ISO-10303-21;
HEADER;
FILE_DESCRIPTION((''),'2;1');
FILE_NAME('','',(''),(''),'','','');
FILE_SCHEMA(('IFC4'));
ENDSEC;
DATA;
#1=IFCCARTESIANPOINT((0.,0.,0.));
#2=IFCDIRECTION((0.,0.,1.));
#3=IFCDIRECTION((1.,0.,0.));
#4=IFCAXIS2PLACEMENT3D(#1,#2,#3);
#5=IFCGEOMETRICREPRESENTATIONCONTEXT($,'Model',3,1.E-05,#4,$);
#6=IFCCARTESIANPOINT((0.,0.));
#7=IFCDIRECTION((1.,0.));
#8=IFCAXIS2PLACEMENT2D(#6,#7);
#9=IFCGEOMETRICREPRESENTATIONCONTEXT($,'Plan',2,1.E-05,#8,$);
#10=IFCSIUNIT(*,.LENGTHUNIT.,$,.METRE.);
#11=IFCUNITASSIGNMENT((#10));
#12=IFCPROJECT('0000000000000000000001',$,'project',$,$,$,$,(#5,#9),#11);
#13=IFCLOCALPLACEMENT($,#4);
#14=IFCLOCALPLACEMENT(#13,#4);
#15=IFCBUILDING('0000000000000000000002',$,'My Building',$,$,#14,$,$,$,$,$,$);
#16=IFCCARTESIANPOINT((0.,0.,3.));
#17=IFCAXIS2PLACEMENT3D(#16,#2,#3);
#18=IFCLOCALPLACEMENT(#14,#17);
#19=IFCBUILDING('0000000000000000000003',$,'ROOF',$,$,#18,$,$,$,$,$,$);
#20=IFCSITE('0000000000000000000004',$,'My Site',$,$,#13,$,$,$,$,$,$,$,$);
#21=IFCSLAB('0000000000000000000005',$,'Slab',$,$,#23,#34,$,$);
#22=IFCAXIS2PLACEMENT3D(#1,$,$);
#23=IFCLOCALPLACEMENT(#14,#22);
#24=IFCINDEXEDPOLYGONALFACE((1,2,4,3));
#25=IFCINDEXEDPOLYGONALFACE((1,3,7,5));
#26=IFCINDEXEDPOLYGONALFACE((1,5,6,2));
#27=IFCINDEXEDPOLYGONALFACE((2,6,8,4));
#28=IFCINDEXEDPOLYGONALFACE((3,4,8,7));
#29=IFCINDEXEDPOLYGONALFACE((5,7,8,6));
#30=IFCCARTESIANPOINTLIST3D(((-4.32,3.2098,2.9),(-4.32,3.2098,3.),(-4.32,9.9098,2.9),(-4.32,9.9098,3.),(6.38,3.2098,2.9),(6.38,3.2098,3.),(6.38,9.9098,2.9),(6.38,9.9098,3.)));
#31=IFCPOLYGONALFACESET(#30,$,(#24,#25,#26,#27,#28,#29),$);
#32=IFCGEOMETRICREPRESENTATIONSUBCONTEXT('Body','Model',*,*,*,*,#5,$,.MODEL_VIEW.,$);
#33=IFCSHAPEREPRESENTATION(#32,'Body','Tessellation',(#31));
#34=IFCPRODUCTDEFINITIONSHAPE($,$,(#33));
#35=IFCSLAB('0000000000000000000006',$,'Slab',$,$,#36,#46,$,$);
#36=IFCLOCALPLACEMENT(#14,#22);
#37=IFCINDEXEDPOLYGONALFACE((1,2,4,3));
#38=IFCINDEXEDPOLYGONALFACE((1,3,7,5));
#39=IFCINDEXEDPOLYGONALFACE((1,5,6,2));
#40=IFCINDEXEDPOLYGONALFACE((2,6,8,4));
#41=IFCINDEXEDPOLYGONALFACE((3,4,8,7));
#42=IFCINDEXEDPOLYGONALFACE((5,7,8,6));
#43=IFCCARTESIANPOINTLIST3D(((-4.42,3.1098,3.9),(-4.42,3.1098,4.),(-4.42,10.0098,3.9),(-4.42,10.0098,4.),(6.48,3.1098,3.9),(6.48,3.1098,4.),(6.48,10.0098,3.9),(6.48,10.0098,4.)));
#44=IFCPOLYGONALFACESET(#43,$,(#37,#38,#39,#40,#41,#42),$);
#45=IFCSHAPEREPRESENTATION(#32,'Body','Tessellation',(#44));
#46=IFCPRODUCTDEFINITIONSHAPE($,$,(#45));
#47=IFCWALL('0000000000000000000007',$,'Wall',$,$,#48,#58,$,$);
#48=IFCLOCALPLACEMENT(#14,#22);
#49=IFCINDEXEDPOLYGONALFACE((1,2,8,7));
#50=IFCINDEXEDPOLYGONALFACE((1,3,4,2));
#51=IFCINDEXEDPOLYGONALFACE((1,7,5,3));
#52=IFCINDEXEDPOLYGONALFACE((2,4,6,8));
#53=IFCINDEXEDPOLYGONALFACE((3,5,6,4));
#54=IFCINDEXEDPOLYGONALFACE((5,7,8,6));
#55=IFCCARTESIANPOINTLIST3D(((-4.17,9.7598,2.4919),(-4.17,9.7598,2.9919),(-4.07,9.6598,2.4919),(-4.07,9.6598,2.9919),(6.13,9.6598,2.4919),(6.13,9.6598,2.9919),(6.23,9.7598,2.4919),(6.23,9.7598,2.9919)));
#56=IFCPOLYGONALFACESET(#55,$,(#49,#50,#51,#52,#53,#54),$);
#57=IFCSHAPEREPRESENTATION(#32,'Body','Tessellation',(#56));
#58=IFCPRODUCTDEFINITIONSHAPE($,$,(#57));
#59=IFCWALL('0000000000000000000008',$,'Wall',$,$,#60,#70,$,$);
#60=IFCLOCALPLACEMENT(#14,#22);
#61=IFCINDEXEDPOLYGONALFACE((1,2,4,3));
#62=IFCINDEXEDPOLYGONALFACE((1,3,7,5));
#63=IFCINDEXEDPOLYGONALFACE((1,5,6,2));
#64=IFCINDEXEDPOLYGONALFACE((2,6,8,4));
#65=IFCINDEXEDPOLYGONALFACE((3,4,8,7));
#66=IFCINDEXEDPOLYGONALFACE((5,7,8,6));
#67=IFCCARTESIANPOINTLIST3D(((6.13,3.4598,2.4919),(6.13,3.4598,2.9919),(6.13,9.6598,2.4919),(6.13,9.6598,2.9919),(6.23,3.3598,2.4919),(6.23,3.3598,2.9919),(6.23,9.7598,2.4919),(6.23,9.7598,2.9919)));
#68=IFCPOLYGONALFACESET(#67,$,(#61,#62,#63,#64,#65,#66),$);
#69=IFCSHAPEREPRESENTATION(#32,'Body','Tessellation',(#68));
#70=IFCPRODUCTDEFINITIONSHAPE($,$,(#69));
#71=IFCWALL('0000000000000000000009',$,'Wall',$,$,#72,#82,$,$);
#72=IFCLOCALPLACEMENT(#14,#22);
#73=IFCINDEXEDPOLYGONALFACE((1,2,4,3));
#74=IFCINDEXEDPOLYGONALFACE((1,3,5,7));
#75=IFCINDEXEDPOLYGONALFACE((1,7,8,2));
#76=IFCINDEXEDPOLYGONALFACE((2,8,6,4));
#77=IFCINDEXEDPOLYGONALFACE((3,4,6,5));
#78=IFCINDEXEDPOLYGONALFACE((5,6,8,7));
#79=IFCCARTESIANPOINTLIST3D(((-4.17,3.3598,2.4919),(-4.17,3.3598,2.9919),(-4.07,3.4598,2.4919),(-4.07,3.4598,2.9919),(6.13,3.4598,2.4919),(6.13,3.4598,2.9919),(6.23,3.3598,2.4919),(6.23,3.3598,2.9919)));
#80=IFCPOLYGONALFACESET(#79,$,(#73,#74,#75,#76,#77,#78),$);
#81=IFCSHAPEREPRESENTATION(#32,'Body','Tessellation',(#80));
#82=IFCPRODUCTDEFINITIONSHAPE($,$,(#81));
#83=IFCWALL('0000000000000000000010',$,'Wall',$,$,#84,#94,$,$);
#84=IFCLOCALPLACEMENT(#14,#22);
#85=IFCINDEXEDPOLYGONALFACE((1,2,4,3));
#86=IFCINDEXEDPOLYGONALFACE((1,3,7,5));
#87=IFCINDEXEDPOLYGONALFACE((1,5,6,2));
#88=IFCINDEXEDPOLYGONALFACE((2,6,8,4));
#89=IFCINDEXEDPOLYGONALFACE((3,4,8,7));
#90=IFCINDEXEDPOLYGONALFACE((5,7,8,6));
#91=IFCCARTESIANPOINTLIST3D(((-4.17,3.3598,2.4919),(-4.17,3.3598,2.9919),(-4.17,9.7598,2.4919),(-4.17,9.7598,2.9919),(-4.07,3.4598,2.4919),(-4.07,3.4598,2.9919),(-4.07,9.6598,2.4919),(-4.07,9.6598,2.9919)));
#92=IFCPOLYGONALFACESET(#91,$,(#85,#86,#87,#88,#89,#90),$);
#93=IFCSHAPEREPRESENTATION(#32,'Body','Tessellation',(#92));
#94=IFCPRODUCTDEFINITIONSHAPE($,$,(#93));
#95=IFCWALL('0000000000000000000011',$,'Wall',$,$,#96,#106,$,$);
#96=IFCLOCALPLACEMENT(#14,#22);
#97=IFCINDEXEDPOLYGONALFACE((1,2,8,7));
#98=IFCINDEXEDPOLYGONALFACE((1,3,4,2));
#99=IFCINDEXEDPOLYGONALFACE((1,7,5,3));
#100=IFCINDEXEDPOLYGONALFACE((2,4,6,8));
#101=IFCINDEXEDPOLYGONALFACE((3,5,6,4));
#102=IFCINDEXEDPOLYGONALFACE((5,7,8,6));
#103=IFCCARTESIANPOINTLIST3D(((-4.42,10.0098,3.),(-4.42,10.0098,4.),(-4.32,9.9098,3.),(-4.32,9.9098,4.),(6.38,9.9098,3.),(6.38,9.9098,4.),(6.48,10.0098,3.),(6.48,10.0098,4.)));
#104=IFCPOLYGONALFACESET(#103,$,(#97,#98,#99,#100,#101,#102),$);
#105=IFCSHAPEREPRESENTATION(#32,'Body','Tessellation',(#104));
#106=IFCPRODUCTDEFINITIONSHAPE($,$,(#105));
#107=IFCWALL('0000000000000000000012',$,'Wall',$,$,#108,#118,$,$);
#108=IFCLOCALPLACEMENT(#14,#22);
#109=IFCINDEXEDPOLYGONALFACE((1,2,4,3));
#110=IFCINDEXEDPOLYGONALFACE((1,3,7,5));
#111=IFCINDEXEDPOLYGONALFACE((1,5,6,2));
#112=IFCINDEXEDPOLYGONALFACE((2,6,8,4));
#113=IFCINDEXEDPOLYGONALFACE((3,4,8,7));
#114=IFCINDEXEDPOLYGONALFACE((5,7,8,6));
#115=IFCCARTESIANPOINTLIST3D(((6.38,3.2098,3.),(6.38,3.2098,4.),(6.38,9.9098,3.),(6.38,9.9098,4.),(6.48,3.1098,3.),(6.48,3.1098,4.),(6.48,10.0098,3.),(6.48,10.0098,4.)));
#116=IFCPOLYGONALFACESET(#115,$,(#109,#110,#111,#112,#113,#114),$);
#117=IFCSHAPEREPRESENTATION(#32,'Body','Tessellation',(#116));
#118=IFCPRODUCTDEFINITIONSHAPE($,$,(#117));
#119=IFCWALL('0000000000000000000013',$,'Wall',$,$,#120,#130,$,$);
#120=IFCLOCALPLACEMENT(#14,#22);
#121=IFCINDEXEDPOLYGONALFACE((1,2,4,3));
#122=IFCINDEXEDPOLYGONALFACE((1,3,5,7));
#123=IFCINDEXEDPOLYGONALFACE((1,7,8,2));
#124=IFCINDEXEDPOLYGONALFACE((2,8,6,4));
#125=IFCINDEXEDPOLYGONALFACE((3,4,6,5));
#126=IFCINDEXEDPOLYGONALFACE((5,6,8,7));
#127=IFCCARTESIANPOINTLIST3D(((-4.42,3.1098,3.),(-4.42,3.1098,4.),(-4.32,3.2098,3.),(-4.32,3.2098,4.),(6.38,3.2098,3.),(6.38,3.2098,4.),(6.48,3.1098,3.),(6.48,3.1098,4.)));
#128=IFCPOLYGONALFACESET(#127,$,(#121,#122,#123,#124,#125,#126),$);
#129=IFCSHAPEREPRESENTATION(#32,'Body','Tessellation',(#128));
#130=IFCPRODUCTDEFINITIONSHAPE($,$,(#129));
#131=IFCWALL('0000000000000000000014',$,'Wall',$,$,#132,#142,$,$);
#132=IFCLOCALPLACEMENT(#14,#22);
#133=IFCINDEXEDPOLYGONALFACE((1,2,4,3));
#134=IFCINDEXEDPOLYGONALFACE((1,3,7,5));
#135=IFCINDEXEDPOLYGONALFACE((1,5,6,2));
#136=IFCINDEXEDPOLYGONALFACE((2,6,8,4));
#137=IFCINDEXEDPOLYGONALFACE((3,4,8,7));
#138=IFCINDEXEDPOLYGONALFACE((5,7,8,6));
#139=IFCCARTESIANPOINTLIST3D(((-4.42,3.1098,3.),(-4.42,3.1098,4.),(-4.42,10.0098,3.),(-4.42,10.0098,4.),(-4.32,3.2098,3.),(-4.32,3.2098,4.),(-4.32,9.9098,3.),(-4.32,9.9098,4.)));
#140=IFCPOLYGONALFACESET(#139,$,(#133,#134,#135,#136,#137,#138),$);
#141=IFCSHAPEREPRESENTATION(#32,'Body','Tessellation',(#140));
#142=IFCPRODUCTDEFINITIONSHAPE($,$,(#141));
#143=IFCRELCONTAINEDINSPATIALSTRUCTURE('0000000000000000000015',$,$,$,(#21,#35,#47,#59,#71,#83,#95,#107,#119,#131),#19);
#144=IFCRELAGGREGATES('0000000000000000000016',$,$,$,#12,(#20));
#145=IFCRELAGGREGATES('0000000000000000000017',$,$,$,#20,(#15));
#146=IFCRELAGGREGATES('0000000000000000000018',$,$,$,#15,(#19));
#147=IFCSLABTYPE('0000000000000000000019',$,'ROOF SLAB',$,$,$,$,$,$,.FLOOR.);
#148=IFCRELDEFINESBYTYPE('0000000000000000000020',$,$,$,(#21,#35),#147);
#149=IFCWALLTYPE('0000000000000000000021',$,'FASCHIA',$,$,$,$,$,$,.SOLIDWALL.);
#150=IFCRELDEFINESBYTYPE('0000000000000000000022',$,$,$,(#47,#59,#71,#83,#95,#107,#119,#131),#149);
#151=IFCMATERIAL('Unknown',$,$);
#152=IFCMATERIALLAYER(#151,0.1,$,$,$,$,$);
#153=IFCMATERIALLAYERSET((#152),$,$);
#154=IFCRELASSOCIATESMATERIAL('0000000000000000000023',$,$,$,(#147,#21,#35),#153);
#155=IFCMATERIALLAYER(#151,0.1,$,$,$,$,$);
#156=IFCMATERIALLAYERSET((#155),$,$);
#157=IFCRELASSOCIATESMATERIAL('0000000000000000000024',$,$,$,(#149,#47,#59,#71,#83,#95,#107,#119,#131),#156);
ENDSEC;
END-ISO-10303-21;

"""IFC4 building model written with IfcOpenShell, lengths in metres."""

from ifc_helpers import new_model, si_unit, frame, origin_with_axes, origin_2d_with_axis, place, context, subcontext, project, spatial, line, indexed_curve, outline, extrude, material, layer, layer_set, layer_usage, type_object, element, save


model = new_model("IFC4")

# Units and contexts
model_context = context("Model", 3, precision=1e-05, world=origin_with_axes())
plan_context = context("Plan", 2, precision=1e-05, world=origin_2d_with_axis())
body_context = subcontext(model_context, "Body", "Model", "MODEL_VIEW")
ifc_project = project(units=[si_unit("LENGTHUNIT", "METRE")], contexts=[model_context, plan_context])

# Site, buildings
site_placement = place(None, origin_with_axes())
site = spatial("IfcSite", under=ifc_project, at=site_placement, Name="My Site")
building_1_placement = place(site_placement, origin_with_axes())
building_1 = spatial("IfcBuilding", under=site, at=building_1_placement, Name="My Building")
building_2_placement = place(building_1_placement, frame((0.0, 0.0, 3.0), z_axis=(0.0, 0.0, 1.0), x_axis=(1.0, 0.0, 0.0)))
building_2 = spatial("IfcBuilding", under=building_1, at=building_2_placement, Name="ROOF")

# Slabs
ifc_material = material(Name="Unknown")
ifc_layer_1 = layer(ifc_material, 0.1)
ifc_layer_set_1 = layer_set([ifc_layer_1])
ifc_layer_usage_1 = layer_usage(ifc_layer_set_1, "AXIS3", "POSITIVE", -0.1)
slab_type = type_object("IfcSlabType", Name="ROOF SLAB", PredefinedType="FLOOR", material=ifc_layer_set_1)
slab_1_placement = place(building_2_placement, frame((-4.32, 9.9098, 0.0), z_axis=(0.0, 0.0, 1.0), x_axis=(1.0, 0.0, 0.0)))
element("IfcSlab", 1, at=slab_1_placement, inside=building_2, type_object=slab_type, material=ifc_layer_usage_1, Name="Slab", context=body_context, shape_type="SweptSolid", body=[
    extrude(outline(indexed_curve([(0.0, 0.0), (10.7, 0.0), (10.7, -6.7), (0.0, -6.7), (0.0, 0.0)])), frame((0.0, 0.0, -0.1), z_axis=(0.0, 0.0, 1.0), x_axis=(1.0, 0.0, 0.0)), (0.0, 0.0, 1.0), 0.1),
])
ifc_layer_usage_2 = layer_usage(ifc_layer_set_1, "AXIS3", "POSITIVE", -0.1)
slab_2_placement = place(building_2_placement, frame((-4.42, 10.0098, 1.0), z_axis=(0.0, 0.0, 1.0), x_axis=(1.0, 0.0, 0.0)))
element("IfcSlab", 2, at=slab_2_placement, inside=building_2, type_object=slab_type, material=ifc_layer_usage_2, Name="Slab", context=body_context, shape_type="SweptSolid", body=[
    extrude(outline(indexed_curve([(0.0, 0.0), (10.9, 0.0), (10.9, -6.9), (0.0, -6.9), (0.0, 0.0)])), frame((0.0, 0.0, -0.1), z_axis=(0.0, 0.0, 1.0), x_axis=(1.0, 0.0, 0.0)), (0.0, 0.0, 1.0), 0.1),
])

# Walls
ifc_layer_2 = layer(ifc_material, 0.1)
ifc_layer_set_2 = layer_set([ifc_layer_2])
ifc_layer_usage_3 = layer_usage(ifc_layer_set_2, "AXIS2", "POSITIVE", 0.0)
wall_type = type_object("IfcWallType", Name="FASCHIA", PredefinedType="SOLIDWALL", material=ifc_layer_set_2)
wall_1_placement = place(building_2_placement, frame((-4.07, 9.6598, -0.5081), z_axis=(0.0, 0.0, 1.0), x_axis=(1.0, 0.0, 0.0)))
element("IfcWall", 3, at=wall_1_placement, inside=building_2, type_object=wall_type, material=ifc_layer_usage_3, Name="Wall", context=body_context, shape_type="SweptSolid", body=[
    extrude(outline(indexed_curve([(0.0, 0.0), (-0.1, 0.1), (10.3, 0.1), (10.2, 0.0)], segments=[line(1, 2, 3, 4, 1)])), origin_with_axes(), (0.0, 0.0, 1.0), 0.5),
])
ifc_layer_usage_4 = layer_usage(ifc_layer_set_2, "AXIS2", "POSITIVE", 0.0)
wall_2_placement = place(building_2_placement, frame((6.13, 9.6598, -0.5081), z_axis=(0.0, 0.0, 1.0), x_axis=(0.0, -1.0, 0.0)))
element("IfcWall", 4, at=wall_2_placement, inside=building_2, type_object=wall_type, material=ifc_layer_usage_4, Name="Wall", context=body_context, shape_type="SweptSolid", body=[
    extrude(outline(indexed_curve([(0.0, 0.0), (-0.1, 0.1), (6.3, 0.1), (6.2, 0.0)], segments=[line(1, 2, 3, 4, 1)])), origin_with_axes(), (0.0, 0.0, 1.0), 0.5),
])
ifc_layer_usage_5 = layer_usage(ifc_layer_set_2, "AXIS2", "POSITIVE", 0.0)
wall_3_placement = place(building_2_placement, frame((6.13, 3.4598, -0.5081), z_axis=(0.0, 0.0, 1.0), x_axis=(-1.0, 0.0, 0.0)))
element("IfcWall", 5, at=wall_3_placement, inside=building_2, type_object=wall_type, material=ifc_layer_usage_5, Name="Wall", context=body_context, shape_type="SweptSolid", body=[
    extrude(outline(indexed_curve([(0.0, 0.0), (-0.1, 0.1), (10.3, 0.1), (10.2, 0.0)], segments=[line(1, 2, 3, 4, 1)])), origin_with_axes(), (0.0, 0.0, 1.0), 0.5),
])
ifc_layer_usage_6 = layer_usage(ifc_layer_set_2, "AXIS2", "POSITIVE", 0.0)
wall_4_placement = place(building_2_placement, frame((-4.07, 3.4598, -0.5081), z_axis=(0.0, 0.0, 1.0), x_axis=(0.0, 1.0, 0.0)))
element("IfcWall", 6, at=wall_4_placement, inside=building_2, type_object=wall_type, material=ifc_layer_usage_6, Name="Wall", context=body_context, shape_type="SweptSolid", body=[
    extrude(outline(indexed_curve([(0.0, 0.0), (-0.1, 0.1), (6.3, 0.1), (6.2, 0.0)], segments=[line(1, 2, 3, 4, 1)])), origin_with_axes(), (0.0, 0.0, 1.0), 0.5),
])
ifc_layer_usage_7 = layer_usage(ifc_layer_set_2, "AXIS2", "POSITIVE", 0.0)
wall_5_placement = place(building_2_placement, frame((-4.32, 9.9098, 0.0), z_axis=(0.0, 0.0, 1.0), x_axis=(1.0, 0.0, 0.0)))
element("IfcWall", 7, at=wall_5_placement, inside=building_2, type_object=wall_type, material=ifc_layer_usage_7, Name="Wall", context=body_context, shape_type="SweptSolid", body=[
    extrude(outline(indexed_curve([(0.0, 0.0), (-0.1, 0.1), (10.8, 0.1), (10.7, 0.0)], segments=[line(1, 2, 3, 4, 1)])), origin_with_axes(), (0.0, 0.0, 1.0), 1.0),
])
ifc_layer_usage_8 = layer_usage(ifc_layer_set_2, "AXIS2", "POSITIVE", 0.0)
wall_6_placement = place(building_2_placement, frame((6.38, 9.9098, 0.0), z_axis=(0.0, 0.0, 1.0), x_axis=(0.0, -1.0, 0.0)))
element("IfcWall", 8, at=wall_6_placement, inside=building_2, type_object=wall_type, material=ifc_layer_usage_8, Name="Wall", context=body_context, shape_type="SweptSolid", body=[
    extrude(outline(indexed_curve([(0.0, 0.0), (-0.1, 0.1), (6.8, 0.1), (6.7, 0.0)], segments=[line(1, 2, 3, 4, 1)])), origin_with_axes(), (0.0, 0.0, 1.0), 1.0),
])
ifc_layer_usage_9 = layer_usage(ifc_layer_set_2, "AXIS2", "POSITIVE", 0.0)
wall_7_placement = place(building_2_placement, frame((6.38, 3.2098, 0.0), z_axis=(0.0, 0.0, 1.0), x_axis=(-1.0, 0.0, 0.0)))
element("IfcWall", 9, at=wall_7_placement, inside=building_2, type_object=wall_type, material=ifc_layer_usage_9, Name="Wall", context=body_context, shape_type="SweptSolid", body=[
    extrude(outline(indexed_curve([(0.0, 0.0), (-0.1, 0.1), (10.8, 0.1), (10.7, 0.0)], segments=[line(1, 2, 3, 4, 1)])), origin_with_axes(), (0.0, 0.0, 1.0), 1.0),
])
ifc_layer_usage_10 = layer_usage(ifc_layer_set_2, "AXIS2", "POSITIVE", 0.0)
wall_8_placement = place(building_2_placement, frame((-4.32, 3.2098, 0.0), z_axis=(0.0, 0.0, 1.0), x_axis=(0.0, 1.0, 0.0)))
element("IfcWall", 10, at=wall_8_placement, inside=building_2, type_object=wall_type, material=ifc_layer_usage_10, Name="Wall", context=body_context, shape_type="SweptSolid", body=[
    extrude(outline(indexed_curve([(0.0, 0.0), (-0.1, 0.1), (6.8, 0.1), (6.7, 0.0)], segments=[line(1, 2, 3, 4, 1)])), origin_with_axes(), (0.0, 0.0, 1.0), 1.0),
])

save(model, "model.ifc")
